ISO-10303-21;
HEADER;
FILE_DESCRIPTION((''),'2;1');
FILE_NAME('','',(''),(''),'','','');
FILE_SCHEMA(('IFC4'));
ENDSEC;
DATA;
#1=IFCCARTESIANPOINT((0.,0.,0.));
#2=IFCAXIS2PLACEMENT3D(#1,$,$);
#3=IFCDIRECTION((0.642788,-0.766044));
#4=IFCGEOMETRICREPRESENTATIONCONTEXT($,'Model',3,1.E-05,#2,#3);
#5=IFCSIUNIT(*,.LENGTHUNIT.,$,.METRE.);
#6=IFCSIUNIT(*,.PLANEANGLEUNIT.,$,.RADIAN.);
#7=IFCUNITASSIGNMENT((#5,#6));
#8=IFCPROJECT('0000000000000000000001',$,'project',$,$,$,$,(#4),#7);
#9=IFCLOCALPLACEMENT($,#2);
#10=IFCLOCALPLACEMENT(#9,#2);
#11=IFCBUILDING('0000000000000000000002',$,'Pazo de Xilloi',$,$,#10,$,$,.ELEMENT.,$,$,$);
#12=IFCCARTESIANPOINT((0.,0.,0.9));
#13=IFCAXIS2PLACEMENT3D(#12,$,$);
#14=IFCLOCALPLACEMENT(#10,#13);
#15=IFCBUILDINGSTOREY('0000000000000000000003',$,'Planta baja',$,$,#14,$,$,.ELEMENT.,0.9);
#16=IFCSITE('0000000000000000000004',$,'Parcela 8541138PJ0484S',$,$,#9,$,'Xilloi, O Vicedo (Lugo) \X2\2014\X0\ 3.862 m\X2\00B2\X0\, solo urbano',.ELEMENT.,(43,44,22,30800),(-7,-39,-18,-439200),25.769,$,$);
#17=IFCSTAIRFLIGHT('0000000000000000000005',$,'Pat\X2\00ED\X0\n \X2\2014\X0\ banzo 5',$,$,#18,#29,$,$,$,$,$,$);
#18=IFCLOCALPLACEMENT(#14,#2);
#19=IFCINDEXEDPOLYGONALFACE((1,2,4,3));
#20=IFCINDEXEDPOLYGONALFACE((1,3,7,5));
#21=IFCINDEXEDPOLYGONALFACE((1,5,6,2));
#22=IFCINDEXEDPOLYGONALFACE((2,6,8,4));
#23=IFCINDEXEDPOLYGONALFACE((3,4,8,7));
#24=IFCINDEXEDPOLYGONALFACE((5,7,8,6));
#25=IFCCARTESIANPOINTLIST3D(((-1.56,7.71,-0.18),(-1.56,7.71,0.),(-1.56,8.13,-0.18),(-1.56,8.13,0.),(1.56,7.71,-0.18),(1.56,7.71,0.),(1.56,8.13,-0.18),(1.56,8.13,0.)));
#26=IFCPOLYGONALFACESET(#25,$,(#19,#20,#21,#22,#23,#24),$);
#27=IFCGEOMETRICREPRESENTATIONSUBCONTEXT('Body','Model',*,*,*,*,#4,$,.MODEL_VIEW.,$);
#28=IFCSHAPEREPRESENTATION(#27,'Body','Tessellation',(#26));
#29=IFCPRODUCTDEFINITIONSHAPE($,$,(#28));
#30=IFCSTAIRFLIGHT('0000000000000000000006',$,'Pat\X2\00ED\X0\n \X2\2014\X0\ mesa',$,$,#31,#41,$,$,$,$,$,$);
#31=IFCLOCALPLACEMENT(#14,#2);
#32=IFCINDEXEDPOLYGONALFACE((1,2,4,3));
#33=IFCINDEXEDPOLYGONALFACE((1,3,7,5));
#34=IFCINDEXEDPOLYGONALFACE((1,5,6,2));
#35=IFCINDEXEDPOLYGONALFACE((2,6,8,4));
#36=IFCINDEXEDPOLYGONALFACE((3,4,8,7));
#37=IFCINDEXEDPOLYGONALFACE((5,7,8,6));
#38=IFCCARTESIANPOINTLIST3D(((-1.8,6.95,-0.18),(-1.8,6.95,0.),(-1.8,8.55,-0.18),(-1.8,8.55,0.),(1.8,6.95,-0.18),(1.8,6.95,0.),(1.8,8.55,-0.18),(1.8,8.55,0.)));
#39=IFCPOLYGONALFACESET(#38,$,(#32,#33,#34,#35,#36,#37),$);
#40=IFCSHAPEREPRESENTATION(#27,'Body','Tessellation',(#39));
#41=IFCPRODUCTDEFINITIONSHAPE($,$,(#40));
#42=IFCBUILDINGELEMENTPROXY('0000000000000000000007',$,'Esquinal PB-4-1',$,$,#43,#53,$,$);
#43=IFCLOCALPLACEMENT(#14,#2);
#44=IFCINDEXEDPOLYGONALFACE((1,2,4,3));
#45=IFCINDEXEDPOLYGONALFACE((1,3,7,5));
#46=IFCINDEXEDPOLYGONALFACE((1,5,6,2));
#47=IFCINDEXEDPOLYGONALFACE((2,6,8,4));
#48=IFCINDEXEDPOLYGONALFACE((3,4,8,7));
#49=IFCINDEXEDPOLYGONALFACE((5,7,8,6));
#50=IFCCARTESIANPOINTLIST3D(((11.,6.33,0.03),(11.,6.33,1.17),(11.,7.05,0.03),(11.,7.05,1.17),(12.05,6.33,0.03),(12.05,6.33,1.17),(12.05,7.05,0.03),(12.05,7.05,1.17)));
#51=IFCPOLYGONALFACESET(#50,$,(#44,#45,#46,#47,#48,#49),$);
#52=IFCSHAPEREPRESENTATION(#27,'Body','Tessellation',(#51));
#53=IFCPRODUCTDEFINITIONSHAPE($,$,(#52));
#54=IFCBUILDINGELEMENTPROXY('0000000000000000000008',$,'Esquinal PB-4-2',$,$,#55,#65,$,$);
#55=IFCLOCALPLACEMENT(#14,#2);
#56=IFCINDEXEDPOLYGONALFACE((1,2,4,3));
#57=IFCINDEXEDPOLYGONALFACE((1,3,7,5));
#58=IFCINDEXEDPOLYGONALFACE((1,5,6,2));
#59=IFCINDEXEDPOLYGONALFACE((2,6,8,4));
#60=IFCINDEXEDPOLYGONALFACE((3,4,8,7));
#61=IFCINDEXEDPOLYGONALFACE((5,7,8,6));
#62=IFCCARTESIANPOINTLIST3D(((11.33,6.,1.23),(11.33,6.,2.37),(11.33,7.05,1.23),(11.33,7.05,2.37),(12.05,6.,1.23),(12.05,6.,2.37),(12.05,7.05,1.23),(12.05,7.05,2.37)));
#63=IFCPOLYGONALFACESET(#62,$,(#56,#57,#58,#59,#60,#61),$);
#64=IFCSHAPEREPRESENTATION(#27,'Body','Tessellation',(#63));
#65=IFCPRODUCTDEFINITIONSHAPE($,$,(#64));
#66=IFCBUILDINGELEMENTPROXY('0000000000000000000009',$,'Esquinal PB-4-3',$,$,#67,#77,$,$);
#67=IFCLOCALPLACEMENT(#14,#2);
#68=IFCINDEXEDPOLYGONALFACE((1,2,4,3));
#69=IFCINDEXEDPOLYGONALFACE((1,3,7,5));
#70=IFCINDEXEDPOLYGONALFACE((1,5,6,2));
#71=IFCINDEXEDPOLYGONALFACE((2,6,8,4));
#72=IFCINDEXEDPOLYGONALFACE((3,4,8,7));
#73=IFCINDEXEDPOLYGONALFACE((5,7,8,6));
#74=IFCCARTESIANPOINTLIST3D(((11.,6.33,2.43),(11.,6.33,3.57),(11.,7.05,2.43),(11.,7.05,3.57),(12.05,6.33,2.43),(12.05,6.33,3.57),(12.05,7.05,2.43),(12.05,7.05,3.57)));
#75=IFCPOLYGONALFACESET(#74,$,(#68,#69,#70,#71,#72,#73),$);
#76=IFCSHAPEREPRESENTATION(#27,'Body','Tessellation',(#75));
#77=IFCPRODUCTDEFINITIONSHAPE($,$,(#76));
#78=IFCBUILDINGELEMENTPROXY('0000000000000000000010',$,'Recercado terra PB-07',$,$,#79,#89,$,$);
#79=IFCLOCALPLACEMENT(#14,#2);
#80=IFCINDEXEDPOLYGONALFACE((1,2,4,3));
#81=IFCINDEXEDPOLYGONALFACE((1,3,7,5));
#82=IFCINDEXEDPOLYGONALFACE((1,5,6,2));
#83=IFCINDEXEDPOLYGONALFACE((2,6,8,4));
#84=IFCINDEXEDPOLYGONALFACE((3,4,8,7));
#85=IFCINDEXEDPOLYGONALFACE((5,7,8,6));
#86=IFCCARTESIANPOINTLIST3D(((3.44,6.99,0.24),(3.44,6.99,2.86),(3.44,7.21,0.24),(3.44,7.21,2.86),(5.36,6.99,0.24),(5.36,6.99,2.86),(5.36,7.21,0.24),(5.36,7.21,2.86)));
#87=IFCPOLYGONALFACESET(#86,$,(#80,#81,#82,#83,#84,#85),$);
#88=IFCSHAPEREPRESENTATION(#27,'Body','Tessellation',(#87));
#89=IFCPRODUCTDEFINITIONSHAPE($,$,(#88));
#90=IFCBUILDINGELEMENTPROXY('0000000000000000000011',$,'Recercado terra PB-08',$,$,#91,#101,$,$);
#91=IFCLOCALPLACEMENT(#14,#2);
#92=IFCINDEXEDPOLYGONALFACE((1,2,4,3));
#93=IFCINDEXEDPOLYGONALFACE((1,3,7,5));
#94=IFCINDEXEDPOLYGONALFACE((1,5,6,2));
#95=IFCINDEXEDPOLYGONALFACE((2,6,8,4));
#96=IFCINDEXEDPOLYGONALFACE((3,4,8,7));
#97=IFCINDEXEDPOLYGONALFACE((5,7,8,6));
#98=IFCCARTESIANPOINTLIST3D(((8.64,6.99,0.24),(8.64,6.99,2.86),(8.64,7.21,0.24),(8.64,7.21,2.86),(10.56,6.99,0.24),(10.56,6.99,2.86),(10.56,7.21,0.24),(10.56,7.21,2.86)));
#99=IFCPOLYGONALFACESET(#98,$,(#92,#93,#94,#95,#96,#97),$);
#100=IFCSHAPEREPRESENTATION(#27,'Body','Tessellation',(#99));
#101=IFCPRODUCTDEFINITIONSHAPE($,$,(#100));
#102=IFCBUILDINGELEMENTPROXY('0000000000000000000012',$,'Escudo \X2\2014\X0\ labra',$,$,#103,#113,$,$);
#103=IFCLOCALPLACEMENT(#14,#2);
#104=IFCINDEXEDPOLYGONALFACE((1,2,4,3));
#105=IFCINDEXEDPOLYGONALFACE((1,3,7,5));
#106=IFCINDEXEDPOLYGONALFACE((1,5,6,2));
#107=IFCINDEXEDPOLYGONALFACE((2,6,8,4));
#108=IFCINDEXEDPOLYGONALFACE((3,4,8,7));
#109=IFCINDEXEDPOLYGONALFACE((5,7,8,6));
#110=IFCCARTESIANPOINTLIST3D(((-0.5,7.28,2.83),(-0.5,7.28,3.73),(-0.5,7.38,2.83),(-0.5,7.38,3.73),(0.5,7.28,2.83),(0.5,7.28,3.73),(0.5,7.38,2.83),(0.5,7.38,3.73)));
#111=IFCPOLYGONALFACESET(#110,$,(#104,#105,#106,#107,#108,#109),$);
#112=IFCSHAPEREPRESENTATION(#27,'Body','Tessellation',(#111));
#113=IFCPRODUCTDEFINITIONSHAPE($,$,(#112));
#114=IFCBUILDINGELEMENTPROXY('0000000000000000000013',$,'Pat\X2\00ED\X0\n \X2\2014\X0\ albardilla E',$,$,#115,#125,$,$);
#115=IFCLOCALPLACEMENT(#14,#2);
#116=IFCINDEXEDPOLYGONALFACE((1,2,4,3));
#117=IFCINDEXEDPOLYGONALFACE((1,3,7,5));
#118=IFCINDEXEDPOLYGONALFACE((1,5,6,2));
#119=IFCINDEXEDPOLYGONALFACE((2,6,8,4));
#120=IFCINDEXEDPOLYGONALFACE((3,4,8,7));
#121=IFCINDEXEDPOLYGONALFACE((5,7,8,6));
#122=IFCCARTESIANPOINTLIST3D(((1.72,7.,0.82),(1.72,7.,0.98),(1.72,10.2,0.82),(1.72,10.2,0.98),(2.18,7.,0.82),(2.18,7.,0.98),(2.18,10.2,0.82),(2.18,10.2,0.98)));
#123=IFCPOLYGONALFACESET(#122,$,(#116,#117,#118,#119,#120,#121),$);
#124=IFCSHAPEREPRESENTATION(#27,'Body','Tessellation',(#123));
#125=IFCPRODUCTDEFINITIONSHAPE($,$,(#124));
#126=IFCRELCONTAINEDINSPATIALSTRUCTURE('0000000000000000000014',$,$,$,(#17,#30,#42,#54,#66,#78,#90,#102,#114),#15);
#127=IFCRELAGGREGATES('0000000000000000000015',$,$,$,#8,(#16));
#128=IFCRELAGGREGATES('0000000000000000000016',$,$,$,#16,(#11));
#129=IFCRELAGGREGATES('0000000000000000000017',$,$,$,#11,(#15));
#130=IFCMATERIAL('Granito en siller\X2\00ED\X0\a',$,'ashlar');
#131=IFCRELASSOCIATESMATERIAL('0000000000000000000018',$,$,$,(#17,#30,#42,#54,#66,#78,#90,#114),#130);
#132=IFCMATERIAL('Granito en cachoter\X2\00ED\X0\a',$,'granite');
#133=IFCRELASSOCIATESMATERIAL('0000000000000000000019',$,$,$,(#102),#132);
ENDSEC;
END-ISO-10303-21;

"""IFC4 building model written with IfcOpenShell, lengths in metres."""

from ifc_helpers import new_model, si_unit, direction, frame, origin, origin_2d, place, context, subcontext, project, spatial, rectangle, extrude, material, element, save


model = new_model("IFC4")

# Units and contexts
model_context = context("Model", 3, precision=1e-05, world=origin(), true_north=direction((0.642788, -0.766044)))
body_context = subcontext(model_context, "Body", "Model", "MODEL_VIEW")
ifc_project = project(units=[si_unit("LENGTHUNIT", "METRE"), si_unit("PLANEANGLEUNIT", "RADIAN")], contexts=[model_context])

# Site, building, storey
site_placement = place(None, origin())
site = spatial("IfcSite", under=ifc_project, at=site_placement, Name="Parcela 8541138PJ0484S", LongName="Xilloi, O Vicedo (Lugo) — 3.862 m², solo urbano", CompositionType="ELEMENT", RefLatitude=(43, 44, 22, 30800), RefLongitude=(-7, -39, -18, -439200), RefElevation=25.769)
building_placement = place(site_placement, origin())
building = spatial("IfcBuilding", under=site, at=building_placement, Name="Pazo de Xilloi", CompositionType="ELEMENT")
storey_placement = place(building_placement, frame((0.0, 0.0, 0.9)))
storey = spatial("IfcBuildingStorey", under=building, at=storey_placement, Name="Planta baja", CompositionType="ELEMENT", Elevation=0.9)

# Shared definitions
ifc_material_1 = material(Name="Granito en cachotería", Category="granite")

# Stair flights
ifc_material_2 = material(Name="Granito en sillería", Category="ashlar")
stair_flight_1_placement = place(storey_placement, frame((0.0, 7.92, -0.09)))
element("IfcStairFlight", 1, at=stair_flight_1_placement, inside=storey, material=ifc_material_2, Name="Patín — banzo 5", context=body_context, shape_type="SweptSolid", body=[
    extrude(rectangle(XDim=3.12, YDim=0.42, at=origin_2d()), frame((0.0, 0.0, -0.09)), (0.0, 0.0, 1.0), 0.18),
])
stair_flight_2_placement = place(storey_placement, frame((0.0, 7.75, -0.09)))
element("IfcStairFlight", 2, at=stair_flight_2_placement, inside=storey, material=ifc_material_2, Name="Patín — mesa", context=body_context, shape_type="SweptSolid", body=[
    extrude(rectangle(XDim=3.6, YDim=1.6, at=origin_2d()), frame((0.0, 0.0, -0.09)), (0.0, 0.0, 1.0), 0.18),
])

# Building element proxies
proxy_1_placement = place(storey_placement, frame((11.525, 6.69, 0.6)))
element("IfcBuildingElementProxy", 3, at=proxy_1_placement, inside=storey, material=ifc_material_2, Name="Esquinal PB-4-1", context=body_context, shape_type="SweptSolid", body=[
    extrude(rectangle(XDim=1.05, YDim=0.72, at=origin_2d()), frame((0.0, 0.0, -0.57)), (0.0, 0.0, 1.0), 1.14),
])
proxy_2_placement = place(storey_placement, frame((11.69, 6.525, 1.8)))
element("IfcBuildingElementProxy", 4, at=proxy_2_placement, inside=storey, material=ifc_material_2, Name="Esquinal PB-4-2", context=body_context, shape_type="SweptSolid", body=[
    extrude(rectangle(XDim=0.72, YDim=1.05, at=origin_2d()), frame((0.0, 0.0, -0.57)), (0.0, 0.0, 1.0), 1.14),
])
proxy_3_placement = place(storey_placement, frame((11.525, 6.69, 3.0)))
element("IfcBuildingElementProxy", 5, at=proxy_3_placement, inside=storey, material=ifc_material_2, Name="Esquinal PB-4-3", context=body_context, shape_type="SweptSolid", body=[
    extrude(rectangle(XDim=1.05, YDim=0.72, at=origin_2d()), frame((0.0, 0.0, -0.57)), (0.0, 0.0, 1.0), 1.14),
])
for number, where, name in (
    (6, (4.4, 7.1, 1.55), "Recercado terra PB-07"),
    (7, (9.6, 7.1, 1.55), "Recercado terra PB-08"),
):
    element("IfcBuildingElementProxy", number, at=place(storey_placement, frame(where)), inside=storey, material=ifc_material_2, Name=name, context=body_context, shape_type="SweptSolid", body=[
        extrude(rectangle(XDim=1.92, YDim=0.22, at=origin_2d()), frame((0.0, 0.0, -1.31)), (0.0, 0.0, 1.0), 2.62),
    ])
proxy_4_placement = place(storey_placement, frame((0.0, 7.33, 3.28)))
element("IfcBuildingElementProxy", 8, at=proxy_4_placement, inside=storey, material=ifc_material_1, Name="Escudo — labra", context=body_context, shape_type="SweptSolid", body=[
    extrude(rectangle(XDim=1.0, YDim=0.1, at=origin_2d()), frame((0.0, 0.0, -0.45)), (0.0, 0.0, 1.0), 0.9),
])
proxy_5_placement = place(storey_placement, frame((1.95, 8.6, 0.9)))
element("IfcBuildingElementProxy", 9, at=proxy_5_placement, inside=storey, material=ifc_material_2, Name="Patín — albardilla E", context=body_context, shape_type="SweptSolid", body=[
    extrude(rectangle(XDim=0.46, YDim=3.2, at=origin_2d()), frame((0.0, 0.0, -0.08)), (0.0, 0.0, 1.0), 0.16),
])

save(model, "model.ifc")
